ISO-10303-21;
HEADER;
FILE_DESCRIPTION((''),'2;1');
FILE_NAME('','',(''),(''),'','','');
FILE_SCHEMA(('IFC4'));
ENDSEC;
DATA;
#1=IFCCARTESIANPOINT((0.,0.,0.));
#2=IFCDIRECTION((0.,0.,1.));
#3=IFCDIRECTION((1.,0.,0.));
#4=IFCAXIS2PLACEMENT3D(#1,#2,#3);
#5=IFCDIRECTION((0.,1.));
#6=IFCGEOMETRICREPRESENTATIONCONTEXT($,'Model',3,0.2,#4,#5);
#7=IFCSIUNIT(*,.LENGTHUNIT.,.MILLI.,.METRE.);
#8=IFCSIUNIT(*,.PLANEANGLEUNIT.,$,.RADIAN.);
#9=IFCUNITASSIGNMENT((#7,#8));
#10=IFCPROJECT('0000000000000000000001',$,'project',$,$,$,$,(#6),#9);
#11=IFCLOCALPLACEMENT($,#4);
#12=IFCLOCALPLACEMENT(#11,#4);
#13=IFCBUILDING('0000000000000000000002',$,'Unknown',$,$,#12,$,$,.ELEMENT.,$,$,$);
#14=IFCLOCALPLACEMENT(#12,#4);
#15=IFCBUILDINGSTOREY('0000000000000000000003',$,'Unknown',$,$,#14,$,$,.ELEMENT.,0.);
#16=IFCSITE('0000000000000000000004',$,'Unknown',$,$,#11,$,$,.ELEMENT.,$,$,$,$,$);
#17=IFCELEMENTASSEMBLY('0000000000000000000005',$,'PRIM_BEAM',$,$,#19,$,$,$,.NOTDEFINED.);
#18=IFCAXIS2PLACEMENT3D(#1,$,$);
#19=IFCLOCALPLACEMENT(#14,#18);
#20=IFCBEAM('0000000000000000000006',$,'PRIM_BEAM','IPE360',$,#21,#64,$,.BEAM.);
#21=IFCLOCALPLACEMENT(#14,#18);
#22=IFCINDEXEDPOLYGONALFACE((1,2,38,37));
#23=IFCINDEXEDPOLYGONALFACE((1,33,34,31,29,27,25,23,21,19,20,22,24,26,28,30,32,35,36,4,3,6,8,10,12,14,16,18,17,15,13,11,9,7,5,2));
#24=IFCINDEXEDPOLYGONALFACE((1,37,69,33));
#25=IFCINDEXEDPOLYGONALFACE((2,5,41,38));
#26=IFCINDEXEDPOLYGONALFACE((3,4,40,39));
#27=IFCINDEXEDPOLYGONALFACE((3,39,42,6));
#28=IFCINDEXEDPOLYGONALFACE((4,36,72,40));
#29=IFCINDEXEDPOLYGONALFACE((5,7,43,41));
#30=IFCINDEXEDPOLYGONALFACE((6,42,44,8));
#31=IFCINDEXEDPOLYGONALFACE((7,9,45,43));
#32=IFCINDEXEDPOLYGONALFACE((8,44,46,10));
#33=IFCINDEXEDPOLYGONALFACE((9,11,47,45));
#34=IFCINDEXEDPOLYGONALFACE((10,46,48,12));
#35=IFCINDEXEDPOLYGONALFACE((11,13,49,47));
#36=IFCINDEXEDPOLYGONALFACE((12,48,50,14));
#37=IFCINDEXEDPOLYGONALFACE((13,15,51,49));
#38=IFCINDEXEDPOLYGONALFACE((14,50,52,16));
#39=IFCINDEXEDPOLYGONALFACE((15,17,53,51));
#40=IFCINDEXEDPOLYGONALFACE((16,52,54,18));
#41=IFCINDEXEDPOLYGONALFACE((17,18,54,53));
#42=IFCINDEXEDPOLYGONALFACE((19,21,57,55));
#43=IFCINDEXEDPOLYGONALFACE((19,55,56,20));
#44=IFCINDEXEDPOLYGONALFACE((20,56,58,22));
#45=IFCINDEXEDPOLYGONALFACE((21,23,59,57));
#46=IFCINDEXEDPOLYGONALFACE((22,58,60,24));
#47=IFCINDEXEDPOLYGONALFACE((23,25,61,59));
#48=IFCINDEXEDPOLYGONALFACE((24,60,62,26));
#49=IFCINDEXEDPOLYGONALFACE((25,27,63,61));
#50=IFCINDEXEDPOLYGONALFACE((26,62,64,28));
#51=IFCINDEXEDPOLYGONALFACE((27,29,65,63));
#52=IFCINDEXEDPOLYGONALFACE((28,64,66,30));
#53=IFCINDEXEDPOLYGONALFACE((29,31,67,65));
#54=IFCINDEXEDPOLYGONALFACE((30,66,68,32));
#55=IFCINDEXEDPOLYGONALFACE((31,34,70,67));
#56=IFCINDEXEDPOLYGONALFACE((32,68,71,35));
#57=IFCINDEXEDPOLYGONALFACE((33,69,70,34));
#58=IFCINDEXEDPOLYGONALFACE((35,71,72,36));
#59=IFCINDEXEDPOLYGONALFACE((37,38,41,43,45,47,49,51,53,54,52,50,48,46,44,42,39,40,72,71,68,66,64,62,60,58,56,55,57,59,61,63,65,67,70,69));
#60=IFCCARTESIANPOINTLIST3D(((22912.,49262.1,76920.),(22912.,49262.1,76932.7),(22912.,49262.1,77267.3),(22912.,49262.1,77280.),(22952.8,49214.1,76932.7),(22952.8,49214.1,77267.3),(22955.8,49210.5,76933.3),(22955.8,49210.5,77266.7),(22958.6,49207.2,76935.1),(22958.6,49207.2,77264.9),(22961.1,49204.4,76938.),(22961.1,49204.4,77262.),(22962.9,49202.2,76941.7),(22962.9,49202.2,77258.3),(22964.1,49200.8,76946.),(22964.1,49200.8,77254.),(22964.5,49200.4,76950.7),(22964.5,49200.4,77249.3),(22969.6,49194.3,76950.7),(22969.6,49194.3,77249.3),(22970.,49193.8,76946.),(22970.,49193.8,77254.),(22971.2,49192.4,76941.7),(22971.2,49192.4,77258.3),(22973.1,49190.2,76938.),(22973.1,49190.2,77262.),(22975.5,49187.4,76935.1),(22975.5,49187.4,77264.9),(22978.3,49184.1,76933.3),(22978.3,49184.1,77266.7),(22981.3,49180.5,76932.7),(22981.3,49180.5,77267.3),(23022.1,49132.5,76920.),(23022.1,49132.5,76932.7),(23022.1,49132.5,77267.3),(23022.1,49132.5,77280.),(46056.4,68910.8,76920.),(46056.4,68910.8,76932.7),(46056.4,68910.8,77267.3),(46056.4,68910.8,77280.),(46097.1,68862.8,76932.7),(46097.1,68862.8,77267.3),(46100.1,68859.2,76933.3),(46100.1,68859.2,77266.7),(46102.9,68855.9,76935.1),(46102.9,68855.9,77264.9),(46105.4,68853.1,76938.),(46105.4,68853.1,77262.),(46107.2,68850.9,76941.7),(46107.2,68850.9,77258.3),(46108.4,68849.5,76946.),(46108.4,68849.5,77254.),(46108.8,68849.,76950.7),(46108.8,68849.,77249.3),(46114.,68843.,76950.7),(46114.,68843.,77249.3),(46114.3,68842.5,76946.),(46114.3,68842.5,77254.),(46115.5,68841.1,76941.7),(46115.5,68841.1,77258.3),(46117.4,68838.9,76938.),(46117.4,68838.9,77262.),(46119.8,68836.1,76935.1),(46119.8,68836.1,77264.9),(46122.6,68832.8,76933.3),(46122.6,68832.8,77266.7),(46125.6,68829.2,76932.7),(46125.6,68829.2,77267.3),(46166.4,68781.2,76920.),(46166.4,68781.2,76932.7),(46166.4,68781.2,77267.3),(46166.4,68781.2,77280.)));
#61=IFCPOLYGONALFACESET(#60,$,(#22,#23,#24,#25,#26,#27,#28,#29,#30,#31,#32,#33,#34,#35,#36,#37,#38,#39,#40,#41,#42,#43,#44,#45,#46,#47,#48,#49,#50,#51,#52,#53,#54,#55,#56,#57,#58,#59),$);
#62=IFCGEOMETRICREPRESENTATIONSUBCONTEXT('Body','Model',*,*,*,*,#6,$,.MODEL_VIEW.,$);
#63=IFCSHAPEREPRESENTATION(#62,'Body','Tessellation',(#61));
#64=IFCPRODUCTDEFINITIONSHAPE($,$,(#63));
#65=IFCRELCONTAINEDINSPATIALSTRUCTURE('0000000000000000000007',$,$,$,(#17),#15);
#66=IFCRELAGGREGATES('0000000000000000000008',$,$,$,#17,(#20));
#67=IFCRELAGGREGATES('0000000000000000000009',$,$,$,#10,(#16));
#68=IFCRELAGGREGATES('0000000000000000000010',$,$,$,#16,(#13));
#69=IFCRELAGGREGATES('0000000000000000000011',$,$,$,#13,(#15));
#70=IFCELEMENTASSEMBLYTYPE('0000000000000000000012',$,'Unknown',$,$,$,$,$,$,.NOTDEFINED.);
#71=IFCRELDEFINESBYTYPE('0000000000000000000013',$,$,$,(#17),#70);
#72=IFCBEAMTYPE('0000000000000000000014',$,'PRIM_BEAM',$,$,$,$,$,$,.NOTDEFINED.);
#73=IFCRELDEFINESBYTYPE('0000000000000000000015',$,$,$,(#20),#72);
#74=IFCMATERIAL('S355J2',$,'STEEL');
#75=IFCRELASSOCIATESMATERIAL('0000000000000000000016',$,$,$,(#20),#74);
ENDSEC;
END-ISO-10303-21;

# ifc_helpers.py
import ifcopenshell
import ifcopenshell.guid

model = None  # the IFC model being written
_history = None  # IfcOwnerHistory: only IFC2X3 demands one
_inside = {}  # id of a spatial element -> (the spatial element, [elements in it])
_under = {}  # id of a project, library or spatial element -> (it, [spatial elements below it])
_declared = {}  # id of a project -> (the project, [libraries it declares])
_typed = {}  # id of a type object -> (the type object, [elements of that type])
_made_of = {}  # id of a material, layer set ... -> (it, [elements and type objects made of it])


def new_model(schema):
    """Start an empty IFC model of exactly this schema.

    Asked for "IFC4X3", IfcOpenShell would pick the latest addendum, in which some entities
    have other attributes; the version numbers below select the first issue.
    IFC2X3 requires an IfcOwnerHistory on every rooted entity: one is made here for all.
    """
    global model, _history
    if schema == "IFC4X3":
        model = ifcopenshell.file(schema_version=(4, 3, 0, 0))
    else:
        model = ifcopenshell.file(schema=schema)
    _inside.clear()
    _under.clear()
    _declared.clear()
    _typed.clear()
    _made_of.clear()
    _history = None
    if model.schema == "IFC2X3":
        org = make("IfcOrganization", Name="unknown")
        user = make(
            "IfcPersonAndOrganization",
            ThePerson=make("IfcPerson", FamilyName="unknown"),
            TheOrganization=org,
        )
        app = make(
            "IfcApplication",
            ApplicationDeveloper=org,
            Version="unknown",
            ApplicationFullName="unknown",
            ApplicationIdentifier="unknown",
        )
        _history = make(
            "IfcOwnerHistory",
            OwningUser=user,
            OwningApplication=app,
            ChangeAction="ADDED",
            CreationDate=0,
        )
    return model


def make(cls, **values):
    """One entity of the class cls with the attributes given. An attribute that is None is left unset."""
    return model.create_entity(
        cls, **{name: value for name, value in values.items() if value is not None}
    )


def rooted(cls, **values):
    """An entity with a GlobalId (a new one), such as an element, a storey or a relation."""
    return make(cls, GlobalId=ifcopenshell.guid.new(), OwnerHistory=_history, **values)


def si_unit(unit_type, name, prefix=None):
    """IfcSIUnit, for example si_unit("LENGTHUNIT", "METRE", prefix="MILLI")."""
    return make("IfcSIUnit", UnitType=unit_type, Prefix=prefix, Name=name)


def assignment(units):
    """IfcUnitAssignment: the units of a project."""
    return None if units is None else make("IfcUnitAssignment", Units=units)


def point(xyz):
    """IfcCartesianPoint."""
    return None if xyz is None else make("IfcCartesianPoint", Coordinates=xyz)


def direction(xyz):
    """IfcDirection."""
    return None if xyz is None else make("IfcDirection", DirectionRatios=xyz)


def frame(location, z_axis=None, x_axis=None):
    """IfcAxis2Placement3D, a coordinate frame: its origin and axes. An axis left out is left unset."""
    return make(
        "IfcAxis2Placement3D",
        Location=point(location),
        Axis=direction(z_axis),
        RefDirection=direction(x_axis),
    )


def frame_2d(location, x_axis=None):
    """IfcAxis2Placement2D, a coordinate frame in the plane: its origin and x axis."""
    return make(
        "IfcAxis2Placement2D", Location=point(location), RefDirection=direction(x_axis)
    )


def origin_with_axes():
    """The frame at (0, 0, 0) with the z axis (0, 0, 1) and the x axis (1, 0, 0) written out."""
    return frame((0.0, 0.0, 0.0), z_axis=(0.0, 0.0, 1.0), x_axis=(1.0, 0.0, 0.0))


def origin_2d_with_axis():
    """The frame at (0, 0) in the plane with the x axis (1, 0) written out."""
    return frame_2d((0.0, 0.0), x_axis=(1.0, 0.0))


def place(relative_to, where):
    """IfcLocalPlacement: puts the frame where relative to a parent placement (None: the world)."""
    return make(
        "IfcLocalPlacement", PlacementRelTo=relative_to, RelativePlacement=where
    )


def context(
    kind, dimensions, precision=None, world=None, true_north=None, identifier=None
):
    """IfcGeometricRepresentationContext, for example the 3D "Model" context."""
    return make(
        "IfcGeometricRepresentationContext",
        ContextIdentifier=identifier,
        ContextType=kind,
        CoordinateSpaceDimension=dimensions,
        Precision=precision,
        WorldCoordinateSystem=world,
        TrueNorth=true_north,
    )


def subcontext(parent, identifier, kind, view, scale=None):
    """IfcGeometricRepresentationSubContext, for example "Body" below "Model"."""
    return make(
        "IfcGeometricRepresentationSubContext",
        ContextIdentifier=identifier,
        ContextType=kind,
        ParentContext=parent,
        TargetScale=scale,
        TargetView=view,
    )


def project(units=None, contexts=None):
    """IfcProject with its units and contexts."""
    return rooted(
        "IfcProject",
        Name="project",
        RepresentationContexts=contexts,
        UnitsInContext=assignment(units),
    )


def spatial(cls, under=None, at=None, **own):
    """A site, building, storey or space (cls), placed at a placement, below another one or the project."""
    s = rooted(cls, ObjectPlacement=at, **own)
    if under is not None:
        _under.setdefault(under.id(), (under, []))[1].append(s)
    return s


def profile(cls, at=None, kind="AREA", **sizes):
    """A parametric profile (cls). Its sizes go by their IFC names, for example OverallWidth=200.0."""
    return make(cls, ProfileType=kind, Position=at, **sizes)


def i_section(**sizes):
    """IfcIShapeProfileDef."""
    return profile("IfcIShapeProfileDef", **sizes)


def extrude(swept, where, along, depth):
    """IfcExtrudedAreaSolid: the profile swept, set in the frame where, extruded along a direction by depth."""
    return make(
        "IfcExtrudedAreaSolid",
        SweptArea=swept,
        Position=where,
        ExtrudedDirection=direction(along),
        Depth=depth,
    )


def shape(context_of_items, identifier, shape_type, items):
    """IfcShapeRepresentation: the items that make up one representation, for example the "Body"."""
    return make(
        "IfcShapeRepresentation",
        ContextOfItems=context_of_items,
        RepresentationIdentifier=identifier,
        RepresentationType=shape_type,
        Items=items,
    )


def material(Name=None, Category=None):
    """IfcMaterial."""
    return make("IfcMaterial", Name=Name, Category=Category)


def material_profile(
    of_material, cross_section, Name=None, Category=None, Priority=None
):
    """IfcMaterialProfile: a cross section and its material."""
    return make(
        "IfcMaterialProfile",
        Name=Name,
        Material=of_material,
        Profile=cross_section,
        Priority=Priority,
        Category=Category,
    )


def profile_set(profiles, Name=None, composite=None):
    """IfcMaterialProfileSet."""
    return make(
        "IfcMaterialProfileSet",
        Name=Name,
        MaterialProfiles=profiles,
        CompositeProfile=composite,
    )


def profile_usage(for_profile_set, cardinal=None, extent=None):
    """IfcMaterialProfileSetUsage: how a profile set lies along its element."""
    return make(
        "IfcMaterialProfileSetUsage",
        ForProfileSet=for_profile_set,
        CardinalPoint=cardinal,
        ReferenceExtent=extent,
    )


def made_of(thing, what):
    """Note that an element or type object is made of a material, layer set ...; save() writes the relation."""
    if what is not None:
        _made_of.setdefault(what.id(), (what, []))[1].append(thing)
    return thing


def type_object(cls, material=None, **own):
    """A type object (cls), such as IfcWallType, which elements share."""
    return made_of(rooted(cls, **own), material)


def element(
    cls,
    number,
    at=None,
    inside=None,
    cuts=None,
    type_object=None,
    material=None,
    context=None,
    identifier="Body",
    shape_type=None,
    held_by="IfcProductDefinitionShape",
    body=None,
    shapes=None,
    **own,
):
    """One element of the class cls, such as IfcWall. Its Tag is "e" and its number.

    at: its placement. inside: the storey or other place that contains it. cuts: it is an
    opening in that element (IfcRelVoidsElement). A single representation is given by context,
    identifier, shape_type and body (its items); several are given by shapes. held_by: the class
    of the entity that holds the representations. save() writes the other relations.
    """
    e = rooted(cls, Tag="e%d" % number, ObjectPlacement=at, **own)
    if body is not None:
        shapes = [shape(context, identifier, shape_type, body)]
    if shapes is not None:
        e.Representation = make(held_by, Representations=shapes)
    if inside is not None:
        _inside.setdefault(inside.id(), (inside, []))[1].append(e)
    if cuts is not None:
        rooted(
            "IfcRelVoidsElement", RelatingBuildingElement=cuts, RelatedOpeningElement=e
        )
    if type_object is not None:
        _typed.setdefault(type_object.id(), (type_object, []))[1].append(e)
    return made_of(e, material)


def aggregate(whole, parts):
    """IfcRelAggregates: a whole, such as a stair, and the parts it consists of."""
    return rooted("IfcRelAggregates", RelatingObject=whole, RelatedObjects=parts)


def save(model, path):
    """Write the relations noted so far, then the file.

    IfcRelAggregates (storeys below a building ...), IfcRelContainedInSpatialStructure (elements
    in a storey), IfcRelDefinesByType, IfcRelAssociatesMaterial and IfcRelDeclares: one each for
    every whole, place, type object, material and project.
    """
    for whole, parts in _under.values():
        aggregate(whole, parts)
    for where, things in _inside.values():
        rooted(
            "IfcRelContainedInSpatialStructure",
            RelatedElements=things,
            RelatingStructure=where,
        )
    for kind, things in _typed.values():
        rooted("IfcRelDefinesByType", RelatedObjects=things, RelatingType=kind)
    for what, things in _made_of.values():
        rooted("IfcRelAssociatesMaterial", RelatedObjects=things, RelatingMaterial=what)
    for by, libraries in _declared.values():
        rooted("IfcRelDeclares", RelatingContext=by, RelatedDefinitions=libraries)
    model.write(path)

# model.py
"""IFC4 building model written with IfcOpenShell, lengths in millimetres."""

from ifc_helpers import new_model, si_unit, direction, frame, origin_with_axes, origin_2d_with_axis, place, context, subcontext, project, spatial, i_section, extrude, material, material_profile, profile_set, profile_usage, type_object, element, aggregate, save


model = new_model("IFC4")

# Units and contexts
model_context = context("Model", 3, precision=0.2, world=origin_with_axes(), true_north=direction((0.0, 1.0)))
body_context = subcontext(model_context, "Body", "Model", "MODEL_VIEW")
ifc_project = project(units=[si_unit("LENGTHUNIT", "METRE", prefix="MILLI"), si_unit("PLANEANGLEUNIT", "RADIAN")], contexts=[model_context])

# Site, building, storey
site_placement = place(None, origin_with_axes())
site = spatial("IfcSite", under=ifc_project, at=site_placement, Name="Unknown", CompositionType="ELEMENT")
building_placement = place(site_placement, origin_with_axes())
building = spatial("IfcBuilding", under=site, at=building_placement, Name="Unknown", CompositionType="ELEMENT")
storey_placement = place(building_placement, origin_with_axes())
storey = spatial("IfcBuildingStorey", under=building, at=storey_placement, Name="Unknown", CompositionType="ELEMENT", Elevation=0.0)

# Shared definitions
element_assembly_type = type_object("IfcElementAssemblyType", Name="Unknown", PredefinedType="NOTDEFINED")
ifc_material_1 = material(Name="S355J2", Category="STEEL")

# Element assembly, beam
assembly_1_placement = place(storey_placement, frame((22967.1, 49197.3, 77100.0), z_axis=(0.64719, -0.762329, 0.0), x_axis=(0.762329, 0.64719, 0.0)))
assembly_1 = element("IfcElementAssembly", 1, at=assembly_1_placement, inside=storey, type_object=element_assembly_type, Name="PRIM_BEAM", PredefinedType="NOTDEFINED")
ifc_material_profile_1 = material_profile(ifc_material_1, i_section(OverallWidth=170.0, OverallDepth=360.0, WebThickness=8.0, FlangeThickness=12.7, FilletRadius=18.0, FlangeEdgeRadius=0.0, FlangeSlope=0.0, at=origin_2d_with_axis()), Name="IPE360")
ifc_profile_set_1 = profile_set([ifc_material_profile_1])
ifc_profile_usage_1 = profile_usage(ifc_profile_set_1, cardinal=2)
beam_type_1 = type_object("IfcBeamType", Name="PRIM_BEAM")
beam_1_placement = place(assembly_1_placement, origin_with_axes())
beam_1 = element("IfcBeam", 2, at=beam_1_placement, type_object=beam_type_1, material=ifc_profile_usage_1, Name="PRIM_BEAM", Description="IPE360", PredefinedType="BEAM", context=body_context, shape_type="SolidModel", body=[
    extrude(i_section(OverallWidth=170.0, OverallDepth=360.0, WebThickness=8.0, FlangeThickness=12.7, FilletRadius=18.0, FlangeEdgeRadius=0.0, FlangeSlope=0.0, at=origin_2d_with_axis()), frame((0.0, 0.0, 0.0), z_axis=(-1.0, 0.0, 0.0), x_axis=(0.0, 0.0, 1.0)), (0.0, 0.0, -1.0), 30360.0),
])
aggregate(assembly_1, [beam_1])

save(model, "model.ifc")
